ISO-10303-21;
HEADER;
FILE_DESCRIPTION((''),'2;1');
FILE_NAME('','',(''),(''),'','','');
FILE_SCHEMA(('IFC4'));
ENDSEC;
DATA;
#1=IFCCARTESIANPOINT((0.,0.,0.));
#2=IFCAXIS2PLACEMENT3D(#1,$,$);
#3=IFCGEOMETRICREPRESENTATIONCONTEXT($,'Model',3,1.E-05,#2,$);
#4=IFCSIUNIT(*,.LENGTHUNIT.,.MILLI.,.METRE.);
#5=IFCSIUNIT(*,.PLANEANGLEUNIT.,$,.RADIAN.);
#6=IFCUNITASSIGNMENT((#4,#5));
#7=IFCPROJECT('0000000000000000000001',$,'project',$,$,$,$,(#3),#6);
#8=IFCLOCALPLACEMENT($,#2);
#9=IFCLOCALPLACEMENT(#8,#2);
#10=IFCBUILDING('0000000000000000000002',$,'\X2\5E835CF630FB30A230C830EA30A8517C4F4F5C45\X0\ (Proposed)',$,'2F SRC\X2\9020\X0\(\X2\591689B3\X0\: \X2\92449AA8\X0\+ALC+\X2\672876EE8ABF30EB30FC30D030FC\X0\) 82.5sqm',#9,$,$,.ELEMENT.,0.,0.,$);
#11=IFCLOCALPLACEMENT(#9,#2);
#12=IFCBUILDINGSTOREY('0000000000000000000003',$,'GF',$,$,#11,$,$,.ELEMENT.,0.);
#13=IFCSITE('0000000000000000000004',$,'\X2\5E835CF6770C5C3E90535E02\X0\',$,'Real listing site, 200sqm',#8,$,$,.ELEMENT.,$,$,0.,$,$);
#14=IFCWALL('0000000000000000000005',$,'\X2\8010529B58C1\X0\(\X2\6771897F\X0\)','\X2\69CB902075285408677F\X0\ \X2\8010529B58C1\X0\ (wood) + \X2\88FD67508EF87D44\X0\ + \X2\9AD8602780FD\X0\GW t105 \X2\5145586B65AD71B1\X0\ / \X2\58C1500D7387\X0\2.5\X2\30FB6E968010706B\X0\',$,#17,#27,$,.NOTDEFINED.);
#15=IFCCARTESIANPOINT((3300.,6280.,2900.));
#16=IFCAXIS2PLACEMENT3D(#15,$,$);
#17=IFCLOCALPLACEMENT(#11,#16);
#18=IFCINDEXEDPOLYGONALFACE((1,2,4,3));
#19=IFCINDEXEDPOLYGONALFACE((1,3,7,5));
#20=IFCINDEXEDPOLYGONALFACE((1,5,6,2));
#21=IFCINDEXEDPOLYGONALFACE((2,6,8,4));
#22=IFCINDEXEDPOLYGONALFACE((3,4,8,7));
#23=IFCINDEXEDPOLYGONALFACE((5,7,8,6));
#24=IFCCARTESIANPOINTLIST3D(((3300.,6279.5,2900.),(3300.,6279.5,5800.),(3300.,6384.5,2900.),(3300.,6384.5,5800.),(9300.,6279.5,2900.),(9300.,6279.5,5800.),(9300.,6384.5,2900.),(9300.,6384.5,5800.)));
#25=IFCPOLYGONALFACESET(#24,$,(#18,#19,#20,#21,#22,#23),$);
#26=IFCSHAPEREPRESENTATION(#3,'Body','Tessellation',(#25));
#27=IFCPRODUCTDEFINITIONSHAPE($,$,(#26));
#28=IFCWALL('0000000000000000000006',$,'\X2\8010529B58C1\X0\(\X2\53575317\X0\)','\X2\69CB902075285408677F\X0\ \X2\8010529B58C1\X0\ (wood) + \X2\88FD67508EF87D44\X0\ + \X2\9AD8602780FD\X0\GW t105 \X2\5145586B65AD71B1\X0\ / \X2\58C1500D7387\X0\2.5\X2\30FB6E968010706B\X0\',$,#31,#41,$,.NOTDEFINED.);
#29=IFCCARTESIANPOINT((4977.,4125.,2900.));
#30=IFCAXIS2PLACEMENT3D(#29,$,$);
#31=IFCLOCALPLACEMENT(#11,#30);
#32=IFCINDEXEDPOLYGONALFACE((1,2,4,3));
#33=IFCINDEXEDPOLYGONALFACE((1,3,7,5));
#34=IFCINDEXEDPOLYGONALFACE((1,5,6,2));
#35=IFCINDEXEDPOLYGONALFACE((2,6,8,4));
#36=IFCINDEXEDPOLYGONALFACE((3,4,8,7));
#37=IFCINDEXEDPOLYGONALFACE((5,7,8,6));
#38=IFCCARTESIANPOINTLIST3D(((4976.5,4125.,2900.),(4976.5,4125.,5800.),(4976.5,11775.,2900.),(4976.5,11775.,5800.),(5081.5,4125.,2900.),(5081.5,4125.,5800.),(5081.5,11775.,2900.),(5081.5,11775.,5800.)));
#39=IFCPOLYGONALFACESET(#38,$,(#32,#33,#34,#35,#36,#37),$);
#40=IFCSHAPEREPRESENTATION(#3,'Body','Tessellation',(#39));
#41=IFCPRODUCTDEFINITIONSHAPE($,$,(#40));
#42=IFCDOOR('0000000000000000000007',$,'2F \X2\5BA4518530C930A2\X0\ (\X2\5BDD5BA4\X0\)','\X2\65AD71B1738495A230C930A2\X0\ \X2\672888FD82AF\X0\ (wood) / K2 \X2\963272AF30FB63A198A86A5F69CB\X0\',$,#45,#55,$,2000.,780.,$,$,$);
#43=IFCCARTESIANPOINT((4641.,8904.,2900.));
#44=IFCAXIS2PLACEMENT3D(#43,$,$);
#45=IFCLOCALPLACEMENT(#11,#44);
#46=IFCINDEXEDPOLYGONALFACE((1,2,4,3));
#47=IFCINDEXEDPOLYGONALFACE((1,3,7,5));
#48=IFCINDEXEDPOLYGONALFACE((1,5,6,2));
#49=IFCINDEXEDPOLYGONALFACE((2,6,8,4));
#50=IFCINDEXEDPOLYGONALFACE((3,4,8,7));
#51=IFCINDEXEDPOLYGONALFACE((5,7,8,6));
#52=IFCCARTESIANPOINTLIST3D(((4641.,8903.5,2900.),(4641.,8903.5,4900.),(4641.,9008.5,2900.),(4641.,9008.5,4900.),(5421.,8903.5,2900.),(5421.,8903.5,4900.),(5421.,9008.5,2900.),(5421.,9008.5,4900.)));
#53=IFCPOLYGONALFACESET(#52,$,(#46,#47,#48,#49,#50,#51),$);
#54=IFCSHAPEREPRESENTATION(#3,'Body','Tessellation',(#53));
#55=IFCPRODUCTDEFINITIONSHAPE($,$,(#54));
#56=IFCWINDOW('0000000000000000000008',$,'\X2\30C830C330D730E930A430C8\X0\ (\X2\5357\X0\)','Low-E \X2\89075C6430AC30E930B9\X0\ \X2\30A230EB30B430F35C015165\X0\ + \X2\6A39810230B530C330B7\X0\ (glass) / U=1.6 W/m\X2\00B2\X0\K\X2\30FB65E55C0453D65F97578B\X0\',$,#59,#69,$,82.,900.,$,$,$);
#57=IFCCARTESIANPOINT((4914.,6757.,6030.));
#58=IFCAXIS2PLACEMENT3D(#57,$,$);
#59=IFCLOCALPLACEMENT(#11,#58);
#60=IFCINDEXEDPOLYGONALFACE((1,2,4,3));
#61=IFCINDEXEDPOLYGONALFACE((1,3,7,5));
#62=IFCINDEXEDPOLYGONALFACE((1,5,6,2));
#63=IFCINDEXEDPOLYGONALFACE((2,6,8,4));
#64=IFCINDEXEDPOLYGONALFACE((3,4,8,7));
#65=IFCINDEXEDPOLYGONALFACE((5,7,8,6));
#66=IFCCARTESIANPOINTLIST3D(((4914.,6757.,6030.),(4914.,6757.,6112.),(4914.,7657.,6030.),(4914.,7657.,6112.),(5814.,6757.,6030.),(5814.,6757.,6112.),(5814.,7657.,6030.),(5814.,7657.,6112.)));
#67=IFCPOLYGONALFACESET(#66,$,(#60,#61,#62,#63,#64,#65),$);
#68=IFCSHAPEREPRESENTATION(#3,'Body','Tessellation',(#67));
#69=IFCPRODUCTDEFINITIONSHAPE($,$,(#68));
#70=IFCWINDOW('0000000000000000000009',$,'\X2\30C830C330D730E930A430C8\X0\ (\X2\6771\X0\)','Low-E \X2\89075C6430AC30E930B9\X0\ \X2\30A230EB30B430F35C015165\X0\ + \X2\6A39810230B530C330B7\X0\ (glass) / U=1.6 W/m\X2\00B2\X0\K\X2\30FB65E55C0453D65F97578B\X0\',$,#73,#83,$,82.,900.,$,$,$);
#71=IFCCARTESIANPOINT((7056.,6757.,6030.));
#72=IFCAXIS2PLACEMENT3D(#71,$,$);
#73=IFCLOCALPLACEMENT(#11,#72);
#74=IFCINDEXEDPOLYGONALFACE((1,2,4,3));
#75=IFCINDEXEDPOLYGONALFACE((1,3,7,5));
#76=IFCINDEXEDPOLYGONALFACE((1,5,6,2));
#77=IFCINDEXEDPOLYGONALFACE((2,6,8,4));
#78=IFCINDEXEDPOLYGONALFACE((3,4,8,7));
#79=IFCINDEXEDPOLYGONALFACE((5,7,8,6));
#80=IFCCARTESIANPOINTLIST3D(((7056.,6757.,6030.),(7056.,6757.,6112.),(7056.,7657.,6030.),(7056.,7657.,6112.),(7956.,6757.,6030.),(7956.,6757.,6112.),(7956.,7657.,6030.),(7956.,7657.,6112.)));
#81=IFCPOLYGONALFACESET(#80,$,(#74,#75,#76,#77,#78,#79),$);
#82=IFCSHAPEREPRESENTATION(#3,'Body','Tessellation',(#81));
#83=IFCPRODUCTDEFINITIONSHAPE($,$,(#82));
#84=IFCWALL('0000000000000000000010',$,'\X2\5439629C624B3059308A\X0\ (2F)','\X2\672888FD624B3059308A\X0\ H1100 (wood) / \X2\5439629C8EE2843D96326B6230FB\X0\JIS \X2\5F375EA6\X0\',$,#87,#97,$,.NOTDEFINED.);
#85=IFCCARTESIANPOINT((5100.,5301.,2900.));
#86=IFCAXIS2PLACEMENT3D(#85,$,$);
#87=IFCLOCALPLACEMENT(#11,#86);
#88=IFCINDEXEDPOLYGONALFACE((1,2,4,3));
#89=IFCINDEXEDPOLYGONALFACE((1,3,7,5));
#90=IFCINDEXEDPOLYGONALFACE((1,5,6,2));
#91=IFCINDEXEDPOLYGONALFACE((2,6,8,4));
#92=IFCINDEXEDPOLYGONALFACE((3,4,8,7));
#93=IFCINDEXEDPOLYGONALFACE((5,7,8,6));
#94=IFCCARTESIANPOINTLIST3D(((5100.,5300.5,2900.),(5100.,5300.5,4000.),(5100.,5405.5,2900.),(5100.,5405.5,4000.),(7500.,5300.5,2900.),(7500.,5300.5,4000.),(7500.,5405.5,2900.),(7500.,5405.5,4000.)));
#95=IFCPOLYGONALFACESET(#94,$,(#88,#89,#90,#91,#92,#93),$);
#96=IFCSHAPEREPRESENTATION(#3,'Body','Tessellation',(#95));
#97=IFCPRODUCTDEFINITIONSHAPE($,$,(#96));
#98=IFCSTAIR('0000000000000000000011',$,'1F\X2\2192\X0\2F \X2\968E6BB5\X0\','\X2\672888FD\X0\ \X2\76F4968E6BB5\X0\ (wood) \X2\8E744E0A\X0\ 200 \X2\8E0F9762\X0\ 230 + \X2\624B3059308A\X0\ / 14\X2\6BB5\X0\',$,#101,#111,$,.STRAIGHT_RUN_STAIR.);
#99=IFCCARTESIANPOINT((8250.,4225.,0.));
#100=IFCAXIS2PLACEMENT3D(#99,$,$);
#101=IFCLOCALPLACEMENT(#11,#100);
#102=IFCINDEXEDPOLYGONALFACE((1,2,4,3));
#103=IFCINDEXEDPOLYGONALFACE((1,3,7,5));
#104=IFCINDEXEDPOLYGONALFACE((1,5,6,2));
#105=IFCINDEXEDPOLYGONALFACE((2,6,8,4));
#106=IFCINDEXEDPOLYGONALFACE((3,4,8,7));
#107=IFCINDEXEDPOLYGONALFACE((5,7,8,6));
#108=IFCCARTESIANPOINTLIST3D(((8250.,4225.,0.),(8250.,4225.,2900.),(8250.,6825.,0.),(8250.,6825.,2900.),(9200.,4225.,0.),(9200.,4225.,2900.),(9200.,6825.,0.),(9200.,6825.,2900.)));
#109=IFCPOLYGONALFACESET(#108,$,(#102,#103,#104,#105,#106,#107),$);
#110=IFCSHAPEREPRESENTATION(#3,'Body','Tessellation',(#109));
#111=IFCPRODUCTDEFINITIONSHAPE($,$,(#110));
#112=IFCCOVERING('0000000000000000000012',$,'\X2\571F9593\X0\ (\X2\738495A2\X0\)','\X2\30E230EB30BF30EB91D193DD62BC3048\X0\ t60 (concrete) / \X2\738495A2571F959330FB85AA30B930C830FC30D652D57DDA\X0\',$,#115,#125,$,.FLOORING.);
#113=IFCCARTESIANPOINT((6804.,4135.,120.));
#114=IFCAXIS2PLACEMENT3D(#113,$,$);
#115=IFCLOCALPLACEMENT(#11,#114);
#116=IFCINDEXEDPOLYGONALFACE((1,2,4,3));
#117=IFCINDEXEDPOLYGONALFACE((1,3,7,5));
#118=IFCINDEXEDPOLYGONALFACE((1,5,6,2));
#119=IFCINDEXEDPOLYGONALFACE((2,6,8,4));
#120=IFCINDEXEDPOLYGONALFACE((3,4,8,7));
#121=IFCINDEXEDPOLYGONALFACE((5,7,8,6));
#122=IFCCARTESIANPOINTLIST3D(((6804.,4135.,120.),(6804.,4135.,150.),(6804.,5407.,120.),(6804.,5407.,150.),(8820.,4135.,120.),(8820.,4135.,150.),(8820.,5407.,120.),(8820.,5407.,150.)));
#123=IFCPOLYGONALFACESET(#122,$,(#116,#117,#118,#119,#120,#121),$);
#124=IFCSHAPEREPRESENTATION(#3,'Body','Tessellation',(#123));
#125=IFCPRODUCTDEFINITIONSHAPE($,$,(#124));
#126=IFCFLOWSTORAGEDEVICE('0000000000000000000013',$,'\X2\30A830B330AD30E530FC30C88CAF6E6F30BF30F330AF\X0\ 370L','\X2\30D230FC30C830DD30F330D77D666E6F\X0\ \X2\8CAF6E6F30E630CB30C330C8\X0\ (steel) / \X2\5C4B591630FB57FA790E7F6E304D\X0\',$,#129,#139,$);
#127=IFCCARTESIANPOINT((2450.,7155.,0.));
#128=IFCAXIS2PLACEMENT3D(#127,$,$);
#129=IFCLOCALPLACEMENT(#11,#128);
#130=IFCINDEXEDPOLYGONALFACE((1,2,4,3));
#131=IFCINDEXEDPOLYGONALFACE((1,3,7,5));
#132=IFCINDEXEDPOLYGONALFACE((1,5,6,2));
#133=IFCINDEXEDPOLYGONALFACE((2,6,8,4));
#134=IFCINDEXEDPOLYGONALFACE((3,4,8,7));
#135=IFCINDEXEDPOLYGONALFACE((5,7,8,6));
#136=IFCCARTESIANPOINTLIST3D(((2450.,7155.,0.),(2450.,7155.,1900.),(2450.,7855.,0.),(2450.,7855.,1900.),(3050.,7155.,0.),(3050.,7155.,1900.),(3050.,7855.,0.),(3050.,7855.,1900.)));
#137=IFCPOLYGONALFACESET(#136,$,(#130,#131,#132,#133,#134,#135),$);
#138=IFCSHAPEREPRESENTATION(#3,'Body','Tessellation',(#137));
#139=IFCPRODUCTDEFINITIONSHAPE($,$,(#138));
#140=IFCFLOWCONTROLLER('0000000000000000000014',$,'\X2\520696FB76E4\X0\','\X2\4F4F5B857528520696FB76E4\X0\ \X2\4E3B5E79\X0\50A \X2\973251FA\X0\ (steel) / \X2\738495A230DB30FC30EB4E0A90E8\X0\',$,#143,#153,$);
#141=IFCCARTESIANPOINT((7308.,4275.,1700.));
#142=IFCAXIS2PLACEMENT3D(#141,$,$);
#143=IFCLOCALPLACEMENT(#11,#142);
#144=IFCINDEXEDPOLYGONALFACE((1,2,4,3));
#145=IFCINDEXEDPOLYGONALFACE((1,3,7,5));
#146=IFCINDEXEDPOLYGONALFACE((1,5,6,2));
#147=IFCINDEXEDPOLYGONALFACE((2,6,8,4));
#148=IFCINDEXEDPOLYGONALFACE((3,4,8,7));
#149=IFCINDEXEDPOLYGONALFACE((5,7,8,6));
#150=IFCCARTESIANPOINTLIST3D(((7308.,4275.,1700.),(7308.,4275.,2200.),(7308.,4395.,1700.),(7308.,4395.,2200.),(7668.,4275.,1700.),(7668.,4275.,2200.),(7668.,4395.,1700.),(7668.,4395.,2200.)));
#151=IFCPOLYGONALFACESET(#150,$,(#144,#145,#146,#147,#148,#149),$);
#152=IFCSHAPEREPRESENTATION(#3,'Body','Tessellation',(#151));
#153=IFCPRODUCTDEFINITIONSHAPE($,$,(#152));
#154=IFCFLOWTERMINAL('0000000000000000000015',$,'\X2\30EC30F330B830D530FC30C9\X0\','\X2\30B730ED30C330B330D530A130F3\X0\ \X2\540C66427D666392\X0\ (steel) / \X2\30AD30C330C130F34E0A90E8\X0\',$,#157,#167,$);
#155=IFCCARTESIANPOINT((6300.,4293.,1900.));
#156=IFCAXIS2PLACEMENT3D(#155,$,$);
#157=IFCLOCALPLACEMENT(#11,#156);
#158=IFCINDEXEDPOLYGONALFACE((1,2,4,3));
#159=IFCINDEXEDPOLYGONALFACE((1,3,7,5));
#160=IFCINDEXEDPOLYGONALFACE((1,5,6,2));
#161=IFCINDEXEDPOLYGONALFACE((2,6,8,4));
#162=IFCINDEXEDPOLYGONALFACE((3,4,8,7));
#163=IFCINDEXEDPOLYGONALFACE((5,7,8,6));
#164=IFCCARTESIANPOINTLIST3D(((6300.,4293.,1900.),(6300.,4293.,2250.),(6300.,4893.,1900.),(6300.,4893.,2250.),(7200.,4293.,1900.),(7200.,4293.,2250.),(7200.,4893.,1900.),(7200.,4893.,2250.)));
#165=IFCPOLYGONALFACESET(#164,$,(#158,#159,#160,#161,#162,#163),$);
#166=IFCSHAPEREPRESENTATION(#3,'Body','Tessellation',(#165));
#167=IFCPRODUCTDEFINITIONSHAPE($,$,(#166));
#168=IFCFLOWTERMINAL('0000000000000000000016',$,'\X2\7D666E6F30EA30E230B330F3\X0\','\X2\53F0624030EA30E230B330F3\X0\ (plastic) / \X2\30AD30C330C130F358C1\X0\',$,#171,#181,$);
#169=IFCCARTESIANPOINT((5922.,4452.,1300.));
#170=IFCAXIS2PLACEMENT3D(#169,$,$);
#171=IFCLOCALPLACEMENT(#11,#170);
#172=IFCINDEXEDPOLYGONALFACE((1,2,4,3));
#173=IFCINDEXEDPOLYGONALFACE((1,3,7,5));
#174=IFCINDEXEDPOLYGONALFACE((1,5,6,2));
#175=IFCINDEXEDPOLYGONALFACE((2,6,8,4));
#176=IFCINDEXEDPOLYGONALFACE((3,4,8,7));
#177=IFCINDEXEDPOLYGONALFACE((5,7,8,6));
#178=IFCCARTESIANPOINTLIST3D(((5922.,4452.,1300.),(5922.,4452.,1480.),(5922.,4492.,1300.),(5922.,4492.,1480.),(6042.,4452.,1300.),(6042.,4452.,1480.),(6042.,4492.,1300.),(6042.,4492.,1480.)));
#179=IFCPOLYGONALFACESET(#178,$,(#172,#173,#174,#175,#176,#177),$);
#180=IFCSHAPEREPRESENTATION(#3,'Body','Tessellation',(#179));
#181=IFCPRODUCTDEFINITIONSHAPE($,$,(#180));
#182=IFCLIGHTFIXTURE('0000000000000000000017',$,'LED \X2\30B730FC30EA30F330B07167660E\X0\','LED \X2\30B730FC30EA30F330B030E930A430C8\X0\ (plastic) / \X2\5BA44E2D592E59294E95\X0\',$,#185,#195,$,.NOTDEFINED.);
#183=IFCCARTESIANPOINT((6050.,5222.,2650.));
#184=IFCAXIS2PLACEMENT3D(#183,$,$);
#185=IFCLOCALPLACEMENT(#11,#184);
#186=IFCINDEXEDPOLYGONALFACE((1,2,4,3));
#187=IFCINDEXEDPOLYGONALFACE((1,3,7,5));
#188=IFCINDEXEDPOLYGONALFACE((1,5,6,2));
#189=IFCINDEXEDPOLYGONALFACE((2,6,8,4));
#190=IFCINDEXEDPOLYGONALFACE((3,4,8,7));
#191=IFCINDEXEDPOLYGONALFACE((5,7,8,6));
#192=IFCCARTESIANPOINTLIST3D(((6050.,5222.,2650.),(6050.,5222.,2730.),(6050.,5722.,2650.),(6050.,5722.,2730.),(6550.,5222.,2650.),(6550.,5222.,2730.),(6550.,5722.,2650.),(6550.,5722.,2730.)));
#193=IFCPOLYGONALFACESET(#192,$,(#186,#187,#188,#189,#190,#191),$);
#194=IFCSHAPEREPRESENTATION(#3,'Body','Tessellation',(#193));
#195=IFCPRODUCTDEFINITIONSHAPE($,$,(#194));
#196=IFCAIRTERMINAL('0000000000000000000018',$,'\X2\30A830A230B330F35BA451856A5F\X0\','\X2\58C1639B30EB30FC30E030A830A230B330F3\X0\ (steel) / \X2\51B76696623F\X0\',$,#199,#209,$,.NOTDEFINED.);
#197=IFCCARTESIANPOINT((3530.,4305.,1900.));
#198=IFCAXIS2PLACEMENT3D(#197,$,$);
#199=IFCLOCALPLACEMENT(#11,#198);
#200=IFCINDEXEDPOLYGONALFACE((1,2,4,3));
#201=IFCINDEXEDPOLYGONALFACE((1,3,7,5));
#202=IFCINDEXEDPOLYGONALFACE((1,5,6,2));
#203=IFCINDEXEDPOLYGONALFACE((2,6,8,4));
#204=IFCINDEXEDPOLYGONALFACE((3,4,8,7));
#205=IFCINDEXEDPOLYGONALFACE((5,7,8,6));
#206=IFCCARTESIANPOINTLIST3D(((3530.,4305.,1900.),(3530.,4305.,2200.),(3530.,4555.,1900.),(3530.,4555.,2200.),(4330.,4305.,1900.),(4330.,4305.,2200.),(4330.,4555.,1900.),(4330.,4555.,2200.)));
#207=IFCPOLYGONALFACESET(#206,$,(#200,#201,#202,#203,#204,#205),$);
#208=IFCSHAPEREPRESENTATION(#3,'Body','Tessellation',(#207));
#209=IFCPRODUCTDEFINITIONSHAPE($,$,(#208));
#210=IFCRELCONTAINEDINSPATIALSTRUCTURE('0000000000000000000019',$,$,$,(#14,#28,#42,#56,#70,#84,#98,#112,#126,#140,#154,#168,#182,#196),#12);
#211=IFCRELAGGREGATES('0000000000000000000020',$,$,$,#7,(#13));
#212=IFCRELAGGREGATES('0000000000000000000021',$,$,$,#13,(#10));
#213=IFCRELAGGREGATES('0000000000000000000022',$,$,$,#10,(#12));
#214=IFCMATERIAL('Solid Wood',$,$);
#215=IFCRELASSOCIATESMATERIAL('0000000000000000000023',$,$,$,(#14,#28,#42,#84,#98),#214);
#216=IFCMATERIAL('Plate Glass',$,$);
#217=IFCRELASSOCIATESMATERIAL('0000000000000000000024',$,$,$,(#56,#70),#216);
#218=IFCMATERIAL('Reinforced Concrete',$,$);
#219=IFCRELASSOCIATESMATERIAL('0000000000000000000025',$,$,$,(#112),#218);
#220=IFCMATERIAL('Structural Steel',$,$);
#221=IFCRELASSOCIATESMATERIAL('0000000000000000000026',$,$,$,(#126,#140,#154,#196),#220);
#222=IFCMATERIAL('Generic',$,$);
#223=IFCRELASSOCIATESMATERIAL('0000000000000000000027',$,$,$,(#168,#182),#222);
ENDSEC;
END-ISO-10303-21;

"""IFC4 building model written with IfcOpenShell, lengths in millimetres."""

from ifc_helpers import new_model, si_unit, frame, frame_2d, origin, place, context, project, spatial, rectangle, extrude, material, element, fill, save


model = new_model("IFC4")

# Units and contexts
model_context = context("Model", 3, precision=1e-05, world=origin())
ifc_project = project(units=[si_unit("LENGTHUNIT", "METRE", prefix="MILLI"), si_unit("PLANEANGLEUNIT", "RADIAN")], contexts=[model_context])

# Site, building, storey
site_placement = place(None, origin())
site = spatial("IfcSite", under=ifc_project, at=site_placement, Name="広島県尾道市", ObjectType="Real listing site, 200sqm", CompositionType="ELEMENT", RefElevation=0.0)
building_placement = place(site_placement, origin())
building = spatial("IfcBuilding", under=site, at=building_placement, Name="広島・アトリエ兼住居 (Proposed)", ObjectType="2F SRC造(外観: 鉄骨+ALC+木目調ルーバー) 82.5sqm", CompositionType="ELEMENT", ElevationOfRefHeight=0.0, ElevationOfTerrain=0.0)
storey_placement = place(building_placement, origin())
storey = spatial("IfcBuildingStorey", under=building, at=storey_placement, Name="GF", CompositionType="ELEMENT", Elevation=0.0)

# Shared definitions
ifc_material_1 = material(Name="Solid Wood")

# Wall
wall_1_placement = place(storey_placement, frame((3300.0, 6280.0, 2900.0)))
element("IfcWall", 1, at=wall_1_placement, inside=storey, material=ifc_material_1, Name="耐力壁(東西)", Description="構造用合板 耐力壁 (wood) + 製材軸組 + 高性能GW t105 充填断熱 / 壁倍率2.5・準耐火", PredefinedType="NOTDEFINED", context=model_context, shape_type="SweptSolid", body=[
    extrude(rectangle(XDim=6000.0, YDim=105.0, at=frame_2d((3000.0, 52.0))), frame((3300.0, 6280.0, 2900.0)), (0.0, 0.0, 1.0), 2900.0),
])

# Wall, opening, door
wall_2_placement = place(storey_placement, frame((4977.0, 4125.0, 2900.0)))
wall_2 = element("IfcWall", 2, at=wall_2_placement, inside=storey, material=ifc_material_1, Name="耐力壁(南北)", Description="構造用合板 耐力壁 (wood) + 製材軸組 + 高性能GW t105 充填断熱 / 壁倍率2.5・準耐火", PredefinedType="NOTDEFINED", context=model_context, shape_type="SweptSolid", body=[
    extrude(rectangle(XDim=105.0, YDim=7650.0, at=frame_2d((52.0, 3825.0))), frame((4977.0, 4125.0, 2900.0)), (0.0, 0.0, 1.0), 2900.0),
])
opening_placement = place(storey_placement, frame((4641.0, 8904.0, 2900.0)))
opening = element("IfcOpeningElement", 3, at=opening_placement, cuts=wall_2, PredefinedType="NOTDEFINED", context=model_context, shape_type="SweptSolid", body=[
    extrude(rectangle(XDim=780.0, YDim=105.0, at=frame_2d((390.0, 52.0))), frame((4641.0, 8904.0, 2900.0)), (0.0, 0.0, 1.0), 2000.0),
])
door_placement = place(storey_placement, frame((4641.0, 8904.0, 2900.0)))
door = element("IfcDoor", 4, at=door_placement, inside=storey, material=ifc_material_1, Name="2F 室内ドア (寝室)", Description="断熱玄関ドア 木製芯 (wood) / K2 防犯・採風機構", OverallHeight=2000.0, OverallWidth=780.0, context=model_context, shape_type="SweptSolid", body=[
    extrude(rectangle(XDim=780.0, YDim=105.0, at=frame_2d((390.0, 52.0))), frame((4641.0, 8904.0, 2900.0)), (0.0, 0.0, 1.0), 2000.0),
])
fill(opening, door)

# Windows
ifc_material_2 = material(Name="Plate Glass")
window_1_placement = place(storey_placement, frame((4914.0, 6757.0, 6030.0)))
element("IfcWindow", 5, at=window_1_placement, inside=storey, material=ifc_material_2, Name="トップライト (南)", Description="Low-E 複層ガラス アルゴン封入 + 樹脂サッシ (glass) / U=1.6 W/m²K・日射取得型", OverallHeight=82.0, OverallWidth=900.0, context=model_context, shape_type="SweptSolid", body=[
    extrude(rectangle(XDim=900.0, YDim=900.0, at=frame_2d((450.0, 450.0))), frame((4914.0, 6757.0, 6030.0)), (0.0, 0.0, 1.0), 82.0),
])
window_2_placement = place(storey_placement, frame((7056.0, 6757.0, 6030.0)))
element("IfcWindow", 6, at=window_2_placement, inside=storey, material=ifc_material_2, Name="トップライト (東)", Description="Low-E 複層ガラス アルゴン封入 + 樹脂サッシ (glass) / U=1.6 W/m²K・日射取得型", OverallHeight=82.0, OverallWidth=900.0, context=model_context, shape_type="SweptSolid", body=[
    extrude(rectangle(XDim=900.0, YDim=900.0, at=frame_2d((450.0, 450.0))), frame((7056.0, 6757.0, 6030.0)), (0.0, 0.0, 1.0), 82.0),
])

# Wall
wall_3_placement = place(storey_placement, frame((5100.0, 5301.0, 2900.0)))
element("IfcWall", 7, at=wall_3_placement, inside=storey, material=ifc_material_1, Name="吹抜手すり (2F)", Description="木製手すり H1100 (wood) / 吹抜転落防止・JIS 強度", PredefinedType="NOTDEFINED", context=model_context, shape_type="SweptSolid", body=[
    extrude(rectangle(XDim=2400.0, YDim=105.0, at=frame_2d((1200.0, 52.0))), frame((5100.0, 5301.0, 2900.0)), (0.0, 0.0, 1.0), 1100.0),
])

# Stair
stair_placement = place(storey_placement, frame((8250.0, 4225.0, 0.0)))
element("IfcStair", 8, at=stair_placement, inside=storey, material=ifc_material_1, Name="1F→2F 階段", Description="木製 直階段 (wood) 蹴上 200 踏面 230 + 手すり / 14段", PredefinedType="STRAIGHT_RUN_STAIR", context=model_context, shape_type="SweptSolid", body=[
    extrude(rectangle(XDim=950.0, YDim=2600.0, at=frame_2d((475.0, 1300.0))), frame((8250.0, 4225.0, 0.0)), (0.0, 0.0, 1.0), 2900.0),
])

# Covering
ifc_material_3 = material(Name="Reinforced Concrete")
covering_placement = place(storey_placement, frame((6804.0, 4135.0, 120.0)))
element("IfcCovering", 9, at=covering_placement, inside=storey, material=ifc_material_3, Name="土間 (玄関)", Description="モルタル金鏝押え t60 (concrete) / 玄関土間・薪ストーブ動線", PredefinedType="FLOORING", context=model_context, shape_type="SweptSolid", body=[
    extrude(rectangle(XDim=2016.0, YDim=1272.0, at=frame_2d((1008.0, 636.0))), frame((6804.0, 4135.0, 120.0)), (0.0, 0.0, 1.0), 30.0),
])

# Flow storage device
ifc_material_4 = material(Name="Structural Steel")
flow_storage_device_placement = place(storey_placement, frame((2450.0, 7155.0, 0.0)))
element("IfcFlowStorageDevice", 10, at=flow_storage_device_placement, inside=storey, material=ifc_material_4, Name="エコキュート貯湯タンク 370L", Description="ヒートポンプ給湯 貯湯ユニット (steel) / 屋外・基礎置き", context=model_context, shape_type="SweptSolid", body=[
    extrude(rectangle(XDim=600.0, YDim=700.0, at=frame_2d((300.0, 350.0))), frame((2450.0, 7155.0, 0.0)), (0.0, 0.0, 1.0), 1900.0),
])

# Flow controller
flow_controller_placement = place(storey_placement, frame((7308.0, 4275.0, 1700.0)))
element("IfcFlowController", 11, at=flow_controller_placement, inside=storey, material=ifc_material_4, Name="分電盤", Description="住宅用分電盤 主幹50A 露出 (steel) / 玄関ホール上部", context=model_context, shape_type="SweptSolid", body=[
    extrude(rectangle(XDim=360.0, YDim=120.0, at=frame_2d((180.0, 60.0))), frame((7308.0, 4275.0, 1700.0)), (0.0, 0.0, 1.0), 500.0),
])

# Flow terminals
flow_terminal_1_placement = place(storey_placement, frame((6300.0, 4293.0, 1900.0)))
element("IfcFlowTerminal", 12, at=flow_terminal_1_placement, inside=storey, material=ifc_material_4, Name="レンジフード", Description="シロッコファン 同時給排 (steel) / キッチン上部", context=model_context, shape_type="SweptSolid", body=[
    extrude(rectangle(XDim=900.0, YDim=600.0, at=frame_2d((450.0, 300.0))), frame((6300.0, 4293.0, 1900.0)), (0.0, 0.0, 1.0), 350.0),
])
ifc_material_5 = material(Name="Generic")
flow_terminal_2_placement = place(storey_placement, frame((5922.0, 4452.0, 1300.0)))
element("IfcFlowTerminal", 13, at=flow_terminal_2_placement, inside=storey, material=ifc_material_5, Name="給湯リモコン", Description="台所リモコン (plastic) / キッチン壁", context=model_context, shape_type="SweptSolid", body=[
    extrude(rectangle(XDim=120.0, YDim=40.0, at=frame_2d((60.0, 20.0))), frame((5922.0, 4452.0, 1300.0)), (0.0, 0.0, 1.0), 180.0),
])

# Light fixture
light_fixture_1_placement = place(storey_placement, frame((6050.0, 5222.0, 2650.0)))
element("IfcLightFixture", 14, at=light_fixture_1_placement, inside=storey, material=ifc_material_5, Name="LED シーリング照明", Description="LED シーリングライト (plastic) / 室中央天井", PredefinedType="NOTDEFINED", context=model_context, shape_type="SweptSolid", body=[
    extrude(rectangle(XDim=500.0, YDim=500.0, at=frame_2d((250.0, 250.0))), frame((6050.0, 5222.0, 2650.0)), (0.0, 0.0, 1.0), 80.0),
])

# Air terminal
air_terminal_1_placement = place(storey_placement, frame((3530.0, 4305.0, 1900.0)))
element("IfcAirTerminal", 15, at=air_terminal_1_placement, inside=storey, material=ifc_material_4, Name="エアコン室内機", Description="壁掛ルームエアコン (steel) / 冷暖房", PredefinedType="NOTDEFINED", context=model_context, shape_type="SweptSolid", body=[
    extrude(rectangle(XDim=800.0, YDim=250.0, at=frame_2d((400.0, 125.0))), frame((3530.0, 4305.0, 1900.0)), (0.0, 0.0, 1.0), 300.0),
])

save(model, "model.ifc")
